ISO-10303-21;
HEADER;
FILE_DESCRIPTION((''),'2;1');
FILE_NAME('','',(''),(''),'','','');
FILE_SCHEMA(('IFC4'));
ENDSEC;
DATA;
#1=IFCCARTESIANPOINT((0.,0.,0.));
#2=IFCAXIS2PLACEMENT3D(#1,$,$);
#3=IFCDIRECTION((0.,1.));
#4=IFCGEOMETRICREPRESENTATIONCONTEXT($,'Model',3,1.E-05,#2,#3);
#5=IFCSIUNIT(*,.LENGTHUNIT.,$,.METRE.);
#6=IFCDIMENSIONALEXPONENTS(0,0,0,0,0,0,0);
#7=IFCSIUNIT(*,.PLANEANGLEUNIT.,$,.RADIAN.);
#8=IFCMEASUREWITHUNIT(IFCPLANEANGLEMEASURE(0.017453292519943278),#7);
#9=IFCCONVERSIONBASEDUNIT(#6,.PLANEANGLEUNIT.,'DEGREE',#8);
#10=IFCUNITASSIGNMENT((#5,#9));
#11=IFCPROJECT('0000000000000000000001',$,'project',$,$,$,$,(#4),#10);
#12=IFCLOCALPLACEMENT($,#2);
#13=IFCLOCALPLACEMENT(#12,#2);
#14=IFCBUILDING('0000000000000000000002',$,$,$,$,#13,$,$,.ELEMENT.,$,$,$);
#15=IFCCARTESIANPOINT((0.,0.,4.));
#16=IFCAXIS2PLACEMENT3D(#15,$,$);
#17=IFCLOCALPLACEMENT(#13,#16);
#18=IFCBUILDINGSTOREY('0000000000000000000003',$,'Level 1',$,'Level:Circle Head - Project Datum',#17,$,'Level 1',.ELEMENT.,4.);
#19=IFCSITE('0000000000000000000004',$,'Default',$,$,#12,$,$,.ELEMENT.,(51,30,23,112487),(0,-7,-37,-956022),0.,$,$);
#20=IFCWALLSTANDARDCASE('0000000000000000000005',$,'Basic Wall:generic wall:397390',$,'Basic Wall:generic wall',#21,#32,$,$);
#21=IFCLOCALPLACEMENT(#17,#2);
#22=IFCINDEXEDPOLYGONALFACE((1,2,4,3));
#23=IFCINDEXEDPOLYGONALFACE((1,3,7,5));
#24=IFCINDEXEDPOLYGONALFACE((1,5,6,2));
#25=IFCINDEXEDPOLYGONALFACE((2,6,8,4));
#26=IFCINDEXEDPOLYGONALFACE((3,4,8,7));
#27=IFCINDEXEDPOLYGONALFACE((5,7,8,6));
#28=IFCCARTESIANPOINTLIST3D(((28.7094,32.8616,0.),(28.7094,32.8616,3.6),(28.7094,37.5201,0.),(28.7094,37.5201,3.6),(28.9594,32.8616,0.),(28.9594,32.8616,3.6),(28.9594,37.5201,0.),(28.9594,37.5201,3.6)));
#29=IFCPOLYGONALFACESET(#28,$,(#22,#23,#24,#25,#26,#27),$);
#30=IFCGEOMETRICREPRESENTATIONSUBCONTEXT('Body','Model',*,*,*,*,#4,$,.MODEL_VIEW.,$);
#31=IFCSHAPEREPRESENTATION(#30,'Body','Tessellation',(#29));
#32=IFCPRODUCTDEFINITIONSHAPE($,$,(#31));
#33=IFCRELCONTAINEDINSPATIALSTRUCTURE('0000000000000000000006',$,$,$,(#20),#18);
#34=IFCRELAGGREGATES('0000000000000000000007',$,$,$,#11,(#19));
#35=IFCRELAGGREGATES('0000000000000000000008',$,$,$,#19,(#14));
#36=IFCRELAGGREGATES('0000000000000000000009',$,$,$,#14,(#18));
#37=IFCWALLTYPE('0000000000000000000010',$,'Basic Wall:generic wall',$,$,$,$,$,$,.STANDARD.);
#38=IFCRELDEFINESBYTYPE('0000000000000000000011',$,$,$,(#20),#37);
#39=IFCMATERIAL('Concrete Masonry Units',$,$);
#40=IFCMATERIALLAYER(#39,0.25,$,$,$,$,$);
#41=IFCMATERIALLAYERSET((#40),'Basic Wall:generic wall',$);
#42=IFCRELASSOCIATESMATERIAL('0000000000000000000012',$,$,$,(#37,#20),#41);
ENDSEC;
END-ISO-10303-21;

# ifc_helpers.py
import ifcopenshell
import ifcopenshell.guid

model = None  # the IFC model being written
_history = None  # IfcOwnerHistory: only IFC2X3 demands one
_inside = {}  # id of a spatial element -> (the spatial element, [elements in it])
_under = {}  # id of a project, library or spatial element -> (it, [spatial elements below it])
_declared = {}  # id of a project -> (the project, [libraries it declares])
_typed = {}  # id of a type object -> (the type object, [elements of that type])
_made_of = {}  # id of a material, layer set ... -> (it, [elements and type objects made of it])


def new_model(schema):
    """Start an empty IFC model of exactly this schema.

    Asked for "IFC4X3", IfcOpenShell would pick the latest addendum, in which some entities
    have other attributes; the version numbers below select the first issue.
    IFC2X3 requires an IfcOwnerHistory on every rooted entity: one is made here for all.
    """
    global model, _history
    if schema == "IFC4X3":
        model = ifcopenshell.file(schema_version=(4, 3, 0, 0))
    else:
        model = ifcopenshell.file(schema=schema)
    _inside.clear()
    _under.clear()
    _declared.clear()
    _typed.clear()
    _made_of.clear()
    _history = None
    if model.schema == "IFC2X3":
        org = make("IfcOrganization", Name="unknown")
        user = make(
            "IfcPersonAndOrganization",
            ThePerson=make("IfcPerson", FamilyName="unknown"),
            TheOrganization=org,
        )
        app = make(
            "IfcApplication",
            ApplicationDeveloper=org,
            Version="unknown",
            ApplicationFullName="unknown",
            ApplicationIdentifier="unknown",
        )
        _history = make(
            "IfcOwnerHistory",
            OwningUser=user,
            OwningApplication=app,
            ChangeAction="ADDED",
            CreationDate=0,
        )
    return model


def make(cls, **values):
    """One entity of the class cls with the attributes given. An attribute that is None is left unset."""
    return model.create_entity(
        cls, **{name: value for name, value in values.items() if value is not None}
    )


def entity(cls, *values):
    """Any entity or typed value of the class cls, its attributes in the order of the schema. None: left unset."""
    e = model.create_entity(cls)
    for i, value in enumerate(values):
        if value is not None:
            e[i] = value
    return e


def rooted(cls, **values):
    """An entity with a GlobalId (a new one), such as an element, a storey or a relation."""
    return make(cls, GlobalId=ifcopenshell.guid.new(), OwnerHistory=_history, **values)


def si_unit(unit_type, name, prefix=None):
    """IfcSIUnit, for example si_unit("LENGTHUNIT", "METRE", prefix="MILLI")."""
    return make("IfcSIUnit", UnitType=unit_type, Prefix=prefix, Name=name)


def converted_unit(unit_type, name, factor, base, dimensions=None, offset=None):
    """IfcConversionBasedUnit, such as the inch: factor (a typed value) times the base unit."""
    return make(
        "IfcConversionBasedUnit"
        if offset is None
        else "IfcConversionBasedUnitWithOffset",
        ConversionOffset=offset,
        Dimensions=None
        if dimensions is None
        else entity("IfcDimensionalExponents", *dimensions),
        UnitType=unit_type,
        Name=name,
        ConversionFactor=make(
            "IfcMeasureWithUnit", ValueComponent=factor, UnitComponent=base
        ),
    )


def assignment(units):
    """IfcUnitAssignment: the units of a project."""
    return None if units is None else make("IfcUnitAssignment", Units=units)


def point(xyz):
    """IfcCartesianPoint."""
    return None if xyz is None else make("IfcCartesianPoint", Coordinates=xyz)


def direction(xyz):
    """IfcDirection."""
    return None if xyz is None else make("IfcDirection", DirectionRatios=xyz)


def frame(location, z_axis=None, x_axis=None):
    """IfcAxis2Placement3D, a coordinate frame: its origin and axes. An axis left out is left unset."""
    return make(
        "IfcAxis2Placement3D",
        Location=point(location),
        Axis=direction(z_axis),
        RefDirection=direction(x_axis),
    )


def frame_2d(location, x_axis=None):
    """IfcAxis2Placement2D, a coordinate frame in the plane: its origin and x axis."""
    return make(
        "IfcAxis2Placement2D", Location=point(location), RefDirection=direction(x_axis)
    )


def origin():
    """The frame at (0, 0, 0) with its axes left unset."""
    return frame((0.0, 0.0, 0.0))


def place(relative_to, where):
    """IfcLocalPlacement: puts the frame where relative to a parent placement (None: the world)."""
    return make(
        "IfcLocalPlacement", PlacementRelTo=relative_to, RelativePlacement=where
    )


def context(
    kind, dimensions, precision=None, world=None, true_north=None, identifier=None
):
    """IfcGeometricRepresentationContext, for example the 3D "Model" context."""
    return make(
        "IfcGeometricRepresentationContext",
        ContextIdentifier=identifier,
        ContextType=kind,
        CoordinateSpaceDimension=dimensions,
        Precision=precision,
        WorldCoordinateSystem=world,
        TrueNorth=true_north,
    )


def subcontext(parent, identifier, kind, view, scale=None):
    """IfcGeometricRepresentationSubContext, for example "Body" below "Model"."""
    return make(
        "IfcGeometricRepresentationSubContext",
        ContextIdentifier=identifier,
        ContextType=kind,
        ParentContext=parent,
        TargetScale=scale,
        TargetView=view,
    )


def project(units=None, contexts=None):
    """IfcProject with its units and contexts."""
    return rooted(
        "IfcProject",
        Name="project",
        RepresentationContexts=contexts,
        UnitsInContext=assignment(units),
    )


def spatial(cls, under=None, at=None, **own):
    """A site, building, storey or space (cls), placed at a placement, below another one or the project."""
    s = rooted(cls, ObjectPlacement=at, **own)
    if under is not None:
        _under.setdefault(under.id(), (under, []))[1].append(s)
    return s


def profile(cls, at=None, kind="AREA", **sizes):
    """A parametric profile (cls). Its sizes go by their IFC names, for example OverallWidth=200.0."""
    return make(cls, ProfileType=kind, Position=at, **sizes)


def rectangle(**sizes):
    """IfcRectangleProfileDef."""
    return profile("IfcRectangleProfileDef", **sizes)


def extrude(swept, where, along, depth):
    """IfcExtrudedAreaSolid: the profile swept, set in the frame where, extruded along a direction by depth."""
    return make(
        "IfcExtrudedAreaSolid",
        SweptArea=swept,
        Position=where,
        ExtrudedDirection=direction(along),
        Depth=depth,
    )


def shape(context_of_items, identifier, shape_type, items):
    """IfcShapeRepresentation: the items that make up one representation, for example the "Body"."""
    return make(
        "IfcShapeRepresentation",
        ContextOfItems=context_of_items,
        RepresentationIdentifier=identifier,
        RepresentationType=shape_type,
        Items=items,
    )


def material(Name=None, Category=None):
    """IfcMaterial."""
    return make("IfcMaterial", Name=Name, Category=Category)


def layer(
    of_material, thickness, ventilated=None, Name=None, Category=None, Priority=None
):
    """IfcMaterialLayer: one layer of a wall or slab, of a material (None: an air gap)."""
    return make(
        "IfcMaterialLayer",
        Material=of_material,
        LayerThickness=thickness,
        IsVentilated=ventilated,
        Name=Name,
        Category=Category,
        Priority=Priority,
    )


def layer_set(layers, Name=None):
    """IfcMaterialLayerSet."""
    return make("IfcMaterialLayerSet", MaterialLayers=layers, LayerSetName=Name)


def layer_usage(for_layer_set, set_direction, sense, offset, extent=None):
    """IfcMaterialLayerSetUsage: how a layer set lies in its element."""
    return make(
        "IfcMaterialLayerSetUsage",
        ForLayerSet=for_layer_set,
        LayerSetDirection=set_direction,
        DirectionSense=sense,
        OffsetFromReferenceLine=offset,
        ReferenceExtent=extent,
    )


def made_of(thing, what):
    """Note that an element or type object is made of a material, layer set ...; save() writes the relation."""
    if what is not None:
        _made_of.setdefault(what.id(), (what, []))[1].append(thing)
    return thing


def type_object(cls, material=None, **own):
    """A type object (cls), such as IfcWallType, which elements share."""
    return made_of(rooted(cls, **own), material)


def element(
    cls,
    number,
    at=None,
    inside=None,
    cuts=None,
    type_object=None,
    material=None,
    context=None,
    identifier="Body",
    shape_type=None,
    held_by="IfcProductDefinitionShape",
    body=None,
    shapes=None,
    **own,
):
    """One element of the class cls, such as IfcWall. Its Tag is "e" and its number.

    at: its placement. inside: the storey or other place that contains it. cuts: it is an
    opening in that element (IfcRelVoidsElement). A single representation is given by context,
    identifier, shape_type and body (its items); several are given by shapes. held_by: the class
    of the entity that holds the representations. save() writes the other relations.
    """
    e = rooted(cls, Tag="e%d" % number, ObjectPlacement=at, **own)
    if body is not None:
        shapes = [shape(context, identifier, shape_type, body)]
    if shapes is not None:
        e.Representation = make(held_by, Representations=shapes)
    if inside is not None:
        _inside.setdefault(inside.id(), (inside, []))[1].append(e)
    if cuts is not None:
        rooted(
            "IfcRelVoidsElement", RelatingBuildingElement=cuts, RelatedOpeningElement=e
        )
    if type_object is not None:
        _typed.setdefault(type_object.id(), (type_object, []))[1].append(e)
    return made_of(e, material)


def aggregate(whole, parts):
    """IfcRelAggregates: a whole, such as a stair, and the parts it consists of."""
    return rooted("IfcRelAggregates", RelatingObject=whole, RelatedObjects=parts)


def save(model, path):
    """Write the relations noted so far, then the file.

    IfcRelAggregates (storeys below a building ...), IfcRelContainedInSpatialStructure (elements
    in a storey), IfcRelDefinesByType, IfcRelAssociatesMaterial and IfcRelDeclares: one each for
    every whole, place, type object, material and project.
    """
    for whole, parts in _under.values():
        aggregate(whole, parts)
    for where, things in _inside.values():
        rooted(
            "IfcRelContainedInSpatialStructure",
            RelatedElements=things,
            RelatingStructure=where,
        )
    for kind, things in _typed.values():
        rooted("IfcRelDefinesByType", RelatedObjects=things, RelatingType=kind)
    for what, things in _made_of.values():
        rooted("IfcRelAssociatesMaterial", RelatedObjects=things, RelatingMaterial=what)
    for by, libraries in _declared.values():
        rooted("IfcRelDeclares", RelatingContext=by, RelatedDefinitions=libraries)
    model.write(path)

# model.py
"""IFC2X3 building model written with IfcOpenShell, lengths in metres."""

from ifc_helpers import new_model, entity, si_unit, converted_unit, direction, frame, frame_2d, origin, place, context, subcontext, project, spatial, rectangle, extrude, material, layer, layer_set, layer_usage, type_object, element, save


model = new_model("IFC2X3")

# Units and contexts
model_context = context("Model", 3, precision=1e-05, world=origin(), true_north=direction((0.0, 1.0)))
body_context = subcontext(model_context, "Body", "Model", "MODEL_VIEW")
ifc_project = project(units=[si_unit("LENGTHUNIT", "METRE"), converted_unit("PLANEANGLEUNIT", "DEGREE", entity("IfcPlaneAngleMeasure", 0.017453292519943278), si_unit("PLANEANGLEUNIT", "RADIAN"), dimensions=[0, 0, 0, 0, 0, 0, 0])], contexts=[model_context])

# Site, building, storey
site_placement = place(None, origin())
site = spatial("IfcSite", under=ifc_project, at=site_placement, Name="Default", CompositionType="ELEMENT", RefLatitude=(51, 30, 23, 112487), RefLongitude=(0, -7, -37, -956022), RefElevation=0.0)
building_placement = place(site_placement, origin())
building = spatial("IfcBuilding", under=site, at=building_placement, CompositionType="ELEMENT")
storey_placement = place(building_placement, frame((0.0, 0.0, 4.0)))
storey = spatial("IfcBuildingStorey", under=building, at=storey_placement, Name="Level 1", ObjectType="Level:Circle Head - Project Datum", LongName="Level 1", CompositionType="ELEMENT", Elevation=4.0)

# Shared definitions
ifc_material = material(Name="Concrete Masonry Units")
ifc_layer = layer(ifc_material, 0.25)
ifc_layer_set = layer_set([ifc_layer], Name="Basic Wall:generic wall")
wall_type = type_object("IfcWallType", Name="Basic Wall:generic wall", PredefinedType="STANDARD", material=ifc_layer_set)

# Wall
ifc_layer_usage_1 = layer_usage(ifc_layer_set, "AXIS2", "NEGATIVE", 0.125)
wall_1_placement = place(storey_placement, frame((28.8344, 37.5201, 0.0), z_axis=(0.0, 0.0, 1.0), x_axis=(0.0, -1.0, 0.0)))
element("IfcWallStandardCase", 1, at=wall_1_placement, inside=storey, type_object=wall_type, material=ifc_layer_usage_1, Name="Basic Wall:generic wall:397390", ObjectType="Basic Wall:generic wall", context=body_context, shape_type="SweptSolid", body=[
    extrude(rectangle(XDim=4.6586, YDim=0.25, at=frame_2d((2.3293, 0.0), x_axis=(-1.0, 0.0))), origin(), (0.0, 0.0, 1.0), 3.6),
])

save(model, "model.ifc")
